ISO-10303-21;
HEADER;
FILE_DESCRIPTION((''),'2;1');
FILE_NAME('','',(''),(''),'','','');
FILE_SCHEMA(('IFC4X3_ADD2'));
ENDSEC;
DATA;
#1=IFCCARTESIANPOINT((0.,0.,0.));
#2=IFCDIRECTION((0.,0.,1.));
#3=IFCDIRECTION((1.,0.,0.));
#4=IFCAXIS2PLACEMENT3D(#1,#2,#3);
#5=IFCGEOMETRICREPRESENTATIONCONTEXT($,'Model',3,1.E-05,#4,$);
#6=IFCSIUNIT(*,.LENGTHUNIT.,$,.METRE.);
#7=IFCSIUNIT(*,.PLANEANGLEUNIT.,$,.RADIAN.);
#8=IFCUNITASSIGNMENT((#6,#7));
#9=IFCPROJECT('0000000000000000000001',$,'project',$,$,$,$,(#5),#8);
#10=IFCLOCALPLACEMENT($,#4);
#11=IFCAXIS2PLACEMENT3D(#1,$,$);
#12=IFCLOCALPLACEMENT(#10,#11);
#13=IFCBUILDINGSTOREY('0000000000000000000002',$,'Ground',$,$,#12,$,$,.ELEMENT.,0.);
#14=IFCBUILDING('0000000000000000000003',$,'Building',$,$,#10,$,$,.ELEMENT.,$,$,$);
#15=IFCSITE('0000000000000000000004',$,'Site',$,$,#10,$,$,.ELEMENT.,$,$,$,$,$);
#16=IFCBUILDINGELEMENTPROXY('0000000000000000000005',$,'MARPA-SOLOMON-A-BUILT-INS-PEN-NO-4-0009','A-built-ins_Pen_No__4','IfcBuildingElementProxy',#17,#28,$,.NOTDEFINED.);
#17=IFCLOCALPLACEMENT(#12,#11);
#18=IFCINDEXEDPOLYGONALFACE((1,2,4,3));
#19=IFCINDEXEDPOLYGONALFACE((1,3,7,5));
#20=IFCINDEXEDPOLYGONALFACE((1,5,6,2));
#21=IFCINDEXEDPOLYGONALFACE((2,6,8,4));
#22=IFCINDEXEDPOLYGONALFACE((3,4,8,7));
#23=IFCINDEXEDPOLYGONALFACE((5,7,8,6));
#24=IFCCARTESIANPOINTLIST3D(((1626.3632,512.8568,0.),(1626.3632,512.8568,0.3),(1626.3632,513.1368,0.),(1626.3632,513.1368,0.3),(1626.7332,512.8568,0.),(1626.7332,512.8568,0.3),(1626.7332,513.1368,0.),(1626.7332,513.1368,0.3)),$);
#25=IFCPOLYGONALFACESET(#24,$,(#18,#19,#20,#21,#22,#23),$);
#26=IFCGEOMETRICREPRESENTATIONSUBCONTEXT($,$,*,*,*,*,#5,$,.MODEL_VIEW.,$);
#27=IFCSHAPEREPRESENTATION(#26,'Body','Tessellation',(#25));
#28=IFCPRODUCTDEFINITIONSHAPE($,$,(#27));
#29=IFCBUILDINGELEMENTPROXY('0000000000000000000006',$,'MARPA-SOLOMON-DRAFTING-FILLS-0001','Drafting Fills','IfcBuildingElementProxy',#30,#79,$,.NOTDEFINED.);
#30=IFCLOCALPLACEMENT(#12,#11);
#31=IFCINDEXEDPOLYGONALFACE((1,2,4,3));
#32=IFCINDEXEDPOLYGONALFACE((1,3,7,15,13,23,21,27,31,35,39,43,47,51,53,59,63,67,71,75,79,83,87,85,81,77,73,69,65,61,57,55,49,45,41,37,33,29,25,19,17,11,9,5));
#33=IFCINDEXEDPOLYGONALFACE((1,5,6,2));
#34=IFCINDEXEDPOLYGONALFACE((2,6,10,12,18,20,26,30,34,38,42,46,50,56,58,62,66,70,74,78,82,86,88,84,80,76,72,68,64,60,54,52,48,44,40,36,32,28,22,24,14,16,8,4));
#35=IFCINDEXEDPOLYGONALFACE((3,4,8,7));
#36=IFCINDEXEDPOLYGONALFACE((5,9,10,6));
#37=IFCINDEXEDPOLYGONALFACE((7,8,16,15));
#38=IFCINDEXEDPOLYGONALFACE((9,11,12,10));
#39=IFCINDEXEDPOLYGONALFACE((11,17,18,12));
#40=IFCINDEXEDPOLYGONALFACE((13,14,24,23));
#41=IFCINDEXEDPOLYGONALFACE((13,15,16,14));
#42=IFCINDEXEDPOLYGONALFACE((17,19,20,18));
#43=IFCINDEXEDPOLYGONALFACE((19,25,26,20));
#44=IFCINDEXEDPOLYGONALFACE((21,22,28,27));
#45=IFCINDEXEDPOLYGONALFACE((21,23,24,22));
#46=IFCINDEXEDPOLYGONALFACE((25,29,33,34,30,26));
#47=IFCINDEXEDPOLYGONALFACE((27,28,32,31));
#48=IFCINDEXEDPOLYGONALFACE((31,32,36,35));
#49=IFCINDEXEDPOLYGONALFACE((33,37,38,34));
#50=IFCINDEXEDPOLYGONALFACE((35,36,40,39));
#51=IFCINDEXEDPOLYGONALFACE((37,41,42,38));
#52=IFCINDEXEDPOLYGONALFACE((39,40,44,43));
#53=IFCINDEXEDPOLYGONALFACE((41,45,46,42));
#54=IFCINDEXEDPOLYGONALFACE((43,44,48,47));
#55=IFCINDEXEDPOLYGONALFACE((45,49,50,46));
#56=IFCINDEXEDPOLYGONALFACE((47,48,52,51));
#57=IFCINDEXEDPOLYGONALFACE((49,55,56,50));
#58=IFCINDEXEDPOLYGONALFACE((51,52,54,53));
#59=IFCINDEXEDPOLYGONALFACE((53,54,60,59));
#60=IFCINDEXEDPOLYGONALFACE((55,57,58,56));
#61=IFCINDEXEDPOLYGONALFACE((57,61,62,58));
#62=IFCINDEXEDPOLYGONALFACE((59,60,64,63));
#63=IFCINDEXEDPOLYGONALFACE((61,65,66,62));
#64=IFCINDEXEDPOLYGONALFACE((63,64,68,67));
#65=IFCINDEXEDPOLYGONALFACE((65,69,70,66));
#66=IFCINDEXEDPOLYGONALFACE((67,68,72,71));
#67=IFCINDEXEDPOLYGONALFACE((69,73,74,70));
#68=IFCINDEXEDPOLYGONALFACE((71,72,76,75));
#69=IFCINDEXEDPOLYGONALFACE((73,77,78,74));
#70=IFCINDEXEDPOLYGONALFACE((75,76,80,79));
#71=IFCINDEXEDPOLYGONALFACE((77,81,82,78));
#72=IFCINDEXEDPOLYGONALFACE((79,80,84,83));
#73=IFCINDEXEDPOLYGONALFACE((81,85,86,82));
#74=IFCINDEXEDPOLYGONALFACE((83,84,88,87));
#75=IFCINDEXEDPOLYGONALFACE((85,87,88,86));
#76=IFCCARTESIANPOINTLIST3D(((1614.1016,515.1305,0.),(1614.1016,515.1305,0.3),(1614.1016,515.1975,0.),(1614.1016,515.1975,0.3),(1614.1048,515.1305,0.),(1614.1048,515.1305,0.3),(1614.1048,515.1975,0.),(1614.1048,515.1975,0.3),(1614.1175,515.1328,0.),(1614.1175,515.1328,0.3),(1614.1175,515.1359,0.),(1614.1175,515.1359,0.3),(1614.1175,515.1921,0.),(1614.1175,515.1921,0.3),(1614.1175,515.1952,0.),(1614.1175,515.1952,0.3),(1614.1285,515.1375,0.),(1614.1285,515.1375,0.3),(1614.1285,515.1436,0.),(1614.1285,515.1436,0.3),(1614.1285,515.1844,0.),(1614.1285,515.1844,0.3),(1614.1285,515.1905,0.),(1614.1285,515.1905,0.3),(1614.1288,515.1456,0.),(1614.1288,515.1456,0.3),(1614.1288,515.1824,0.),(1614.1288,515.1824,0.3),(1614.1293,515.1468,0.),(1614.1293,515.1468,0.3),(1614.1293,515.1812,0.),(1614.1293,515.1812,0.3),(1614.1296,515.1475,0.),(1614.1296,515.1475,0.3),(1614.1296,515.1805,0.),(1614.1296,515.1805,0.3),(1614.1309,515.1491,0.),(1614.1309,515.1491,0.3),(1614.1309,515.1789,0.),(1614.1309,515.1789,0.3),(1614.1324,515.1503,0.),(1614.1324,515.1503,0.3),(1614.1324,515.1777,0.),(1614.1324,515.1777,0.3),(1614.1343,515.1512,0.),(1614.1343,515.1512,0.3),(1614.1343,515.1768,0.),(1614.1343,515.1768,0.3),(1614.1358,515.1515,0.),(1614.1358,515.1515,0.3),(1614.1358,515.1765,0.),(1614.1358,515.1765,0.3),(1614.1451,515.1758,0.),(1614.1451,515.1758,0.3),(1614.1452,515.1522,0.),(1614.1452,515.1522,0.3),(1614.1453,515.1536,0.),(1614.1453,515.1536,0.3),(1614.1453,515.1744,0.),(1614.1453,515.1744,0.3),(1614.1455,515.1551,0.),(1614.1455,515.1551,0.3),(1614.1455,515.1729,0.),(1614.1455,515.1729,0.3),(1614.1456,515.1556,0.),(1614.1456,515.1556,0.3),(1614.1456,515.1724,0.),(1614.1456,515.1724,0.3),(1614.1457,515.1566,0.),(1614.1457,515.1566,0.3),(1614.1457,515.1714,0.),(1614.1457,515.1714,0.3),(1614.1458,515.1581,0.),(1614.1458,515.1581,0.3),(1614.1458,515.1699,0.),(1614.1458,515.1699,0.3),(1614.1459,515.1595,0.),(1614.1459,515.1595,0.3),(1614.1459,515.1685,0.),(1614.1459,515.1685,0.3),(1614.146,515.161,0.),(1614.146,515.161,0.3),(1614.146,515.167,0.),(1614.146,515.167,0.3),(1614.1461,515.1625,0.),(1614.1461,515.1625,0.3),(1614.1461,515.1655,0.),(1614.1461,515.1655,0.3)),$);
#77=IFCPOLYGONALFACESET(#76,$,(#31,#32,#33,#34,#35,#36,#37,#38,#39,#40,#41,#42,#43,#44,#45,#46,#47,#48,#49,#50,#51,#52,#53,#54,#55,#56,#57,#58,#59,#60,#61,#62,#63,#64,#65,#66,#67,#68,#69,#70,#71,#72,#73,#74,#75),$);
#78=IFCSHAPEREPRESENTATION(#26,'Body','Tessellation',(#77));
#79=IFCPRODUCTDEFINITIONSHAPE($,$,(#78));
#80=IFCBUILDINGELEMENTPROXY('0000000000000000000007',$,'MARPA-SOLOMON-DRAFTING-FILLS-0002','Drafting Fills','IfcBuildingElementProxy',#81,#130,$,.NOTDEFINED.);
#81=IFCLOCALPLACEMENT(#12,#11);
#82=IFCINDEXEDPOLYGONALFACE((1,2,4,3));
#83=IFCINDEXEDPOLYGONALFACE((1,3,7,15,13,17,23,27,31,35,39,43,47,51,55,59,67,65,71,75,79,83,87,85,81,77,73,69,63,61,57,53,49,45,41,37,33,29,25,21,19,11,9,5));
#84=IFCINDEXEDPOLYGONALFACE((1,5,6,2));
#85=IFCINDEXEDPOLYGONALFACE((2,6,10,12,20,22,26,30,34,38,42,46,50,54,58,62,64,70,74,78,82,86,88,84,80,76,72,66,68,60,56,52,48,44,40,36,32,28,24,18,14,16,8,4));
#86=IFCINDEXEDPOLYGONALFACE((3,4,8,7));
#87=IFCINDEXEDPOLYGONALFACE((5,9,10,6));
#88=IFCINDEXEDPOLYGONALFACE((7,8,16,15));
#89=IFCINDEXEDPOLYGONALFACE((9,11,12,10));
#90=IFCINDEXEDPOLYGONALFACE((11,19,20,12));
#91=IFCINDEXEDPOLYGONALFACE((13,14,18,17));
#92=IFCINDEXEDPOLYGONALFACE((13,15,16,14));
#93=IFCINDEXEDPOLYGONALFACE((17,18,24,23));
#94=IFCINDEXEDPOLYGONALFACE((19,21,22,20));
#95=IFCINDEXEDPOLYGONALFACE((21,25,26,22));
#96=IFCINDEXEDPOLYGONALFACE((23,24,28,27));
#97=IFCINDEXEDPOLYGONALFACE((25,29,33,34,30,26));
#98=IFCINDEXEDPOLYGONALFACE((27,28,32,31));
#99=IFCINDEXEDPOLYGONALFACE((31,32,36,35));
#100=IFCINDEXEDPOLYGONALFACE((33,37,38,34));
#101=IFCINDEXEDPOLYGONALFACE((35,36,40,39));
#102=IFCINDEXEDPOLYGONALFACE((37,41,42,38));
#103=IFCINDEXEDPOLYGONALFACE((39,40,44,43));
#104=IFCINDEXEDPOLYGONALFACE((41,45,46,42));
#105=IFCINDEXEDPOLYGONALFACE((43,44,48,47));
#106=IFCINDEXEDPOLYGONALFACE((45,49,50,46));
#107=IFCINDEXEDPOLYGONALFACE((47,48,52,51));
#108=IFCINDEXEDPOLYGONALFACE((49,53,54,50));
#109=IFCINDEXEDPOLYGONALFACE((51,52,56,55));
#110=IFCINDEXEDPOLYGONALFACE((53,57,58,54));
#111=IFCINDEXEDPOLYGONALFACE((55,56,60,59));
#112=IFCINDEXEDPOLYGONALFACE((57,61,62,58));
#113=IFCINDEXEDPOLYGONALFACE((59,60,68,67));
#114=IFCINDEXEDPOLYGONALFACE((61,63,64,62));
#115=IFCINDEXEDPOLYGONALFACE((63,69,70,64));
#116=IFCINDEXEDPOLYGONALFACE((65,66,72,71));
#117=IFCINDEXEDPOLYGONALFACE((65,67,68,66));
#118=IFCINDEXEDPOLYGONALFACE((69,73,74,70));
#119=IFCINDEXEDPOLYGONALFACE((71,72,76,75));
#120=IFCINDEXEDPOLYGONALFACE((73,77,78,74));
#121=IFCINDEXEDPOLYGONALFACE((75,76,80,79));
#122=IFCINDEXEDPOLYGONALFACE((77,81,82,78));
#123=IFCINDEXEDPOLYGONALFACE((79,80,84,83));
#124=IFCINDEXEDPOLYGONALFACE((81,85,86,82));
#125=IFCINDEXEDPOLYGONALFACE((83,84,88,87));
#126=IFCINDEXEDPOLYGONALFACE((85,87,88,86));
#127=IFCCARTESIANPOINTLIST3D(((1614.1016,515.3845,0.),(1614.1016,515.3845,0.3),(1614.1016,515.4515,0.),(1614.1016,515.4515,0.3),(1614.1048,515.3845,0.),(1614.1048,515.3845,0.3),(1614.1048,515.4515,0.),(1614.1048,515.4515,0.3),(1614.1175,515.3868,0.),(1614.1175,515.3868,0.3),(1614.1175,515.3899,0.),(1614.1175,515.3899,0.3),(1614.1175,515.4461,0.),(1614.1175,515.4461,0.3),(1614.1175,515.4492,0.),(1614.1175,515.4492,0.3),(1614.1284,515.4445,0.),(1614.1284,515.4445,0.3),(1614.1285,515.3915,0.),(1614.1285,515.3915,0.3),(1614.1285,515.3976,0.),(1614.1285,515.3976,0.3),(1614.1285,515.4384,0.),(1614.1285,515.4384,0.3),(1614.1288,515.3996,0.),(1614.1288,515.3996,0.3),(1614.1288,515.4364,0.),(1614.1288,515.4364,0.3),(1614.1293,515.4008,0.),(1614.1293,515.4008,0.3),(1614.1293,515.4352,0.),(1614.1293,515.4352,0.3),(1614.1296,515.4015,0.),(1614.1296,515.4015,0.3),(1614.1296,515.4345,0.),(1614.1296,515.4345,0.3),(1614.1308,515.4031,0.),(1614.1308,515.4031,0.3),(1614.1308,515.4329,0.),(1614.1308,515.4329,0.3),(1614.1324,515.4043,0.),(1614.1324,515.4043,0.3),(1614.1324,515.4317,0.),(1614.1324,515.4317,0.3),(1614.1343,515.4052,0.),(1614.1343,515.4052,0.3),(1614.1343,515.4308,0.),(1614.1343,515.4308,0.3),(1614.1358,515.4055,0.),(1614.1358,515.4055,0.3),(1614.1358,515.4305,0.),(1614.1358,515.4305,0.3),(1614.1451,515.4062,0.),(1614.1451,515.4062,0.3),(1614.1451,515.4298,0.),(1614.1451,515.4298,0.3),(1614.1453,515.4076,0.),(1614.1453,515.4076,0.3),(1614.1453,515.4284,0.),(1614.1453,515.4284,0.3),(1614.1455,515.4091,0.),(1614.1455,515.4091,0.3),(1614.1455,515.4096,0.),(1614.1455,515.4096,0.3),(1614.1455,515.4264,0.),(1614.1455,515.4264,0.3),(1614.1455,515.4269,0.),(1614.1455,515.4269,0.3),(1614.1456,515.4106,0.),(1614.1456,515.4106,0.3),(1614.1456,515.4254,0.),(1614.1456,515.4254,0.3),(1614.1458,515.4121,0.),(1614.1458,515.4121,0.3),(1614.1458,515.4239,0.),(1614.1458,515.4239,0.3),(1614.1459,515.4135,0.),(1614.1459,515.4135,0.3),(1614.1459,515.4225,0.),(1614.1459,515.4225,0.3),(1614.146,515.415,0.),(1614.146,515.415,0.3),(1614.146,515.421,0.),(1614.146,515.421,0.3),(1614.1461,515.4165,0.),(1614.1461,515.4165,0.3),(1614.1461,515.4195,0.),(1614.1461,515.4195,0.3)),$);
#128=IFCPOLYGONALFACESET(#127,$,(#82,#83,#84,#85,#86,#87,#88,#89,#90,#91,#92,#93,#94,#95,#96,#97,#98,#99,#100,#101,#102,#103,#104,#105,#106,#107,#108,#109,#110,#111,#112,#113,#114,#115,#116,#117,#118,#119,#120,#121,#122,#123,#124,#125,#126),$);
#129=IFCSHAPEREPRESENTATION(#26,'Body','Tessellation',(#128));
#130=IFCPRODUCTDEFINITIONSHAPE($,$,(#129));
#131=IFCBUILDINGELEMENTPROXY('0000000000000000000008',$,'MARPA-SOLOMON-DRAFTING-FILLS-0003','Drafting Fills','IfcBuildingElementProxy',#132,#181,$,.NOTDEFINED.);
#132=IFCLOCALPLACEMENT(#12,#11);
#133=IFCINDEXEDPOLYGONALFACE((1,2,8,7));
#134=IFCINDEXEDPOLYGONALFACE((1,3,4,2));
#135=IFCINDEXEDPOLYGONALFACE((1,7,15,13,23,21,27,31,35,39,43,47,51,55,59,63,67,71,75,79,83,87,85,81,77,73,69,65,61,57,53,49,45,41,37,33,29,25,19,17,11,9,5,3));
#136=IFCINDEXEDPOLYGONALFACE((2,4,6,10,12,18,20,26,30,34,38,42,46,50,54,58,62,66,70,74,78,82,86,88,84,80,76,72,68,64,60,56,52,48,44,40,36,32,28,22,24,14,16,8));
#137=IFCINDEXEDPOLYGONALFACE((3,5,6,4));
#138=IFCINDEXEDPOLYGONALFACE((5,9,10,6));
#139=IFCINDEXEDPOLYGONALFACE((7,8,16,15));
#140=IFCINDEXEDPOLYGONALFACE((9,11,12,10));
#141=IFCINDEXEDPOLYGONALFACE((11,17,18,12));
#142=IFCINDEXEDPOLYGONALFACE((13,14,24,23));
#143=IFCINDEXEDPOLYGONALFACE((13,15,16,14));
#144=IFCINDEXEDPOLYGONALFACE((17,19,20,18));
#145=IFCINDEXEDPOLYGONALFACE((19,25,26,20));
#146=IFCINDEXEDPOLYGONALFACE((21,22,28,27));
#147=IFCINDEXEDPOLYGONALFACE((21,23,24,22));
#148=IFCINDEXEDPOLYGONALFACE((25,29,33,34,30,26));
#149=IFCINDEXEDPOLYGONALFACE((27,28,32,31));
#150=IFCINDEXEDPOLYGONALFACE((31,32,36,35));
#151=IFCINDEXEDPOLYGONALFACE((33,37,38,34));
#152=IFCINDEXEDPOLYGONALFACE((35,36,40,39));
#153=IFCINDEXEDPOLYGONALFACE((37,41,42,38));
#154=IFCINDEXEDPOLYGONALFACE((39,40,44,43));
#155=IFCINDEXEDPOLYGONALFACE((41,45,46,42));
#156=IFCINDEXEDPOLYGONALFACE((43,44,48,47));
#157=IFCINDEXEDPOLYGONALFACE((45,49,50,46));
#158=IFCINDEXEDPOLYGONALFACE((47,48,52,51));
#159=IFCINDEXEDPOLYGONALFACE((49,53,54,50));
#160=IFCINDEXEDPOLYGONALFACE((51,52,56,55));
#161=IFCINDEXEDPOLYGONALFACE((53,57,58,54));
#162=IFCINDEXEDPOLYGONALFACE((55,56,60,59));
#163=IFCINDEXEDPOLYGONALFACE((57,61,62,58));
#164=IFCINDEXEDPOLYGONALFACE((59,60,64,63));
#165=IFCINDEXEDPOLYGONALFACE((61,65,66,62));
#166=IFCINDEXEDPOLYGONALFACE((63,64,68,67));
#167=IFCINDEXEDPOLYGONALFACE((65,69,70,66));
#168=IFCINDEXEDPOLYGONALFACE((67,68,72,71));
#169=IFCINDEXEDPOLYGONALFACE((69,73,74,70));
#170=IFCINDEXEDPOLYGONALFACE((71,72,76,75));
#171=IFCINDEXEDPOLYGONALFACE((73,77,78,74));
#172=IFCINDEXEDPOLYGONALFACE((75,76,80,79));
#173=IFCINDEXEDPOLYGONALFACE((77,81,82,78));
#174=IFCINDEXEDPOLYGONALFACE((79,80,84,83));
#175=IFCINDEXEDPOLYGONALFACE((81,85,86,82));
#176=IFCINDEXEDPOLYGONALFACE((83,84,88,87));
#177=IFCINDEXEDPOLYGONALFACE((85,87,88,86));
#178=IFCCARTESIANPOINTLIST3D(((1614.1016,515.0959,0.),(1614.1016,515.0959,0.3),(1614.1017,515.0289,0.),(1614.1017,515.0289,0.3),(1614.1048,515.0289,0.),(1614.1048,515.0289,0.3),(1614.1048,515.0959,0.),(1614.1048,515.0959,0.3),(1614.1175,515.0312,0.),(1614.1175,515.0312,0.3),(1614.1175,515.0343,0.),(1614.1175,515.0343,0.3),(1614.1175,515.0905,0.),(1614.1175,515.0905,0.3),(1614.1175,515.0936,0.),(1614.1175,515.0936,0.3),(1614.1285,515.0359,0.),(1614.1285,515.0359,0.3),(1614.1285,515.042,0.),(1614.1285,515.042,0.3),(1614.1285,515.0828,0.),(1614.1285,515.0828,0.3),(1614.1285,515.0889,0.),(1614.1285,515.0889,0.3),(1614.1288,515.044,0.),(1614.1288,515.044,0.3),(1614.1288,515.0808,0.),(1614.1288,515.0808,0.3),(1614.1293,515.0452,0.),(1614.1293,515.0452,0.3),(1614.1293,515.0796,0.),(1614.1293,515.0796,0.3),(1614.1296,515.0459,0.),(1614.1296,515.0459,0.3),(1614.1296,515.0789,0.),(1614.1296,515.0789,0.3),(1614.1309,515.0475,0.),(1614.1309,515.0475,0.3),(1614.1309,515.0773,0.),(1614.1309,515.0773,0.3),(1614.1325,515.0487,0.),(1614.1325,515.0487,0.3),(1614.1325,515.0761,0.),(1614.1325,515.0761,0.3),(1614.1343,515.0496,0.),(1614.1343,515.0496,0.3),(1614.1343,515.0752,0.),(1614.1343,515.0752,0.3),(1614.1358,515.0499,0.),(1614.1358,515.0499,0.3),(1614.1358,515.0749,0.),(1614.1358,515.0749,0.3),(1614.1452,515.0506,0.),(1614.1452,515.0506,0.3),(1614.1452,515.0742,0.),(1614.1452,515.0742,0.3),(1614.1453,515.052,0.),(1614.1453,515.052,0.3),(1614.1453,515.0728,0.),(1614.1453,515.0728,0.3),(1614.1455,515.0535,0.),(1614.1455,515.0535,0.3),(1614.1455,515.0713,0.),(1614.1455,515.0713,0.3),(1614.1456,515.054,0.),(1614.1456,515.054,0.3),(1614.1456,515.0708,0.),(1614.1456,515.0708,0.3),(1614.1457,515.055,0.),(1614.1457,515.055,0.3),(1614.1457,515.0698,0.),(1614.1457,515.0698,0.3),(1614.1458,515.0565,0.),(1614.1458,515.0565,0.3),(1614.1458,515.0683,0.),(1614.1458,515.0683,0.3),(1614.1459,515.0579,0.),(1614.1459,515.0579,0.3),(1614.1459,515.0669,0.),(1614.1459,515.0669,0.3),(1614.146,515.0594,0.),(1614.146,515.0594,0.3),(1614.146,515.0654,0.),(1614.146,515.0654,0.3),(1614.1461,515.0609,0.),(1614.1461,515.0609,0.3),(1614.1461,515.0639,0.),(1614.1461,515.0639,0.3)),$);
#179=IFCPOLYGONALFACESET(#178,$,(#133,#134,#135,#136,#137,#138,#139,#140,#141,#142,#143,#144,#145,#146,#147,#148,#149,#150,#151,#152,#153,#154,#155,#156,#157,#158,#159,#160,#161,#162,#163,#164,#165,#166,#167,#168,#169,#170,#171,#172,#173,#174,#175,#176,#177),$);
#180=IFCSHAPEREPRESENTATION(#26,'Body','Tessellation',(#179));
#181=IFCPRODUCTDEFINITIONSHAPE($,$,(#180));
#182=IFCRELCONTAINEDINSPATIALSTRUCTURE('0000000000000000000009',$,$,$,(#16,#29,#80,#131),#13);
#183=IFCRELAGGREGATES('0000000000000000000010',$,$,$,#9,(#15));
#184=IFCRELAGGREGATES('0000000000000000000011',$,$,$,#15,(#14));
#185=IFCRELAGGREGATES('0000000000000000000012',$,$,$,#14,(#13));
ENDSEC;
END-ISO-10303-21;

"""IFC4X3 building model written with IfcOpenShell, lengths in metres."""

from ifc_helpers import new_model, si_unit, frame, origin, origin_with_axes, place, context, subcontext, project, spatial, polyline, outline, extrude, element, save


model = new_model("IFC4X3")

# Units and contexts
model_context = context("Model", 3, precision=1e-05, world=origin_with_axes())
sub_context = subcontext(model_context, None, None, "MODEL_VIEW")
ifc_project = project(units=[si_unit("LENGTHUNIT", "METRE"), si_unit("PLANEANGLEUNIT", "RADIAN")], contexts=[model_context])

# Site, building, storey
placement = place(None, origin_with_axes())
site = spatial("IfcSite", under=ifc_project, at=placement, Name="Site", CompositionType="ELEMENT")
building = spatial("IfcBuilding", under=site, at=placement, Name="Building", CompositionType="ELEMENT")
storey_placement = place(placement, origin())
storey = spatial("IfcBuildingStorey", under=building, at=storey_placement, Name="Ground", CompositionType="ELEMENT", Elevation=0.0)

# Building element proxies
proxy_1_placement = place(placement, frame((1626.3632, 512.8568, 0.0)))
element("IfcBuildingElementProxy", 1, at=proxy_1_placement, inside=storey, Name="MARPA-SOLOMON-A-BUILT-INS-PEN-NO-4-0009", Description="A-built-ins_Pen_No__4", ObjectType="IfcBuildingElementProxy", PredefinedType="NOTDEFINED", context=sub_context, shape_type="SweptSolid", body=[
    extrude(outline(polyline([(0.0, 0.28), (0.0, 0.0), (0.37, 0.0), (0.37, 0.28), (0.0, 0.28)])), origin(), (0.0, 0.0, 1.0), 0.3),
])
proxy_2_placement = place(placement, frame((1614.1016, 515.1305, 0.0)))
element("IfcBuildingElementProxy", 2, at=proxy_2_placement, inside=storey, Name="MARPA-SOLOMON-DRAFTING-FILLS-0001", Description="Drafting Fills", ObjectType="IfcBuildingElementProxy", PredefinedType="NOTDEFINED", context=sub_context, shape_type="SweptSolid", body=[
    extrude(outline(polyline([(0.0159, 0.0022), (0.0159, 0.0054), (0.0268, 0.007), (0.0268, 0.0131), (0.0272, 0.0151), (0.0277, 0.0162), (0.028, 0.017), (0.0292, 0.0186), (0.0308, 0.0198), (0.0326, 0.0207), (0.0342, 0.021), (0.0435, 0.0216), (0.0437, 0.0231), (0.0439, 0.0246), (0.0439, 0.0251), (0.044, 0.0261), (0.0441, 0.0275), (0.0443, 0.029), (0.0443, 0.0305), (0.0445, 0.032), (0.0445, 0.035), (0.0443, 0.0365), (0.0442, 0.0379), (0.0441, 0.0394), (0.044, 0.0409), (0.0439, 0.0419), (0.0439, 0.0424), (0.0437, 0.0439), (0.0435, 0.0453), (0.0342, 0.046), (0.0326, 0.0463), (0.0308, 0.0471), (0.0292, 0.0484), (0.028, 0.05), (0.0277, 0.0507), (0.0272, 0.0519), (0.0268, 0.0538), (0.0268, 0.06), (0.0159, 0.0616), (0.0159, 0.0647), (0.0032, 0.067), (0.0, 0.067), (0.0, 0.0), (0.0032, 0.0), (0.0159, 0.0022)])), origin(), (0.0, 0.0, 1.0), 0.3),
])
proxy_3_placement = place(placement, frame((1614.1016, 515.3845, 0.0)))
element("IfcBuildingElementProxy", 3, at=proxy_3_placement, inside=storey, Name="MARPA-SOLOMON-DRAFTING-FILLS-0002", Description="Drafting Fills", ObjectType="IfcBuildingElementProxy", PredefinedType="NOTDEFINED", context=sub_context, shape_type="SweptSolid", body=[
    extrude(outline(polyline([(0.0159, 0.0022), (0.0159, 0.0054), (0.0268, 0.007), (0.0268, 0.0131), (0.0272, 0.0151), (0.0277, 0.0162), (0.028, 0.017), (0.0292, 0.0186), (0.0308, 0.0198), (0.0326, 0.0207), (0.0342, 0.021), (0.0435, 0.0216), (0.0437, 0.0231), (0.0439, 0.0246), (0.0439, 0.0251), (0.044, 0.0261), (0.0441, 0.0275), (0.0443, 0.029), (0.0443, 0.0305), (0.0445, 0.032), (0.0445, 0.035), (0.0443, 0.0365), (0.0442, 0.0379), (0.0441, 0.0394), (0.044, 0.0409), (0.0439, 0.0419), (0.0439, 0.0424), (0.0437, 0.0439), (0.0435, 0.0453), (0.0342, 0.046), (0.0326, 0.0463), (0.0308, 0.0471), (0.0292, 0.0484), (0.028, 0.05), (0.0277, 0.0507), (0.0272, 0.0519), (0.0268, 0.0538), (0.0268, 0.06), (0.0159, 0.0616), (0.0159, 0.0647), (0.0032, 0.067), (0.0, 0.067), (0.0, 0.0), (0.0032, 0.0), (0.0159, 0.0022)])), origin(), (0.0, 0.0, 1.0), 0.3),
])
proxy_4_placement = place(placement, frame((1614.1016, 515.0289, 0.0)))
element("IfcBuildingElementProxy", 4, at=proxy_4_placement, inside=storey, Name="MARPA-SOLOMON-DRAFTING-FILLS-0003", Description="Drafting Fills", ObjectType="IfcBuildingElementProxy", PredefinedType="NOTDEFINED", context=sub_context, shape_type="SweptSolid", body=[
    extrude(outline(polyline([(0.0159, 0.0022), (0.0159, 0.0054), (0.0268, 0.007), (0.0268, 0.0131), (0.0272, 0.0151), (0.0277, 0.0162), (0.028, 0.017), (0.0292, 0.0186), (0.0308, 0.0198), (0.0326, 0.0207), (0.0342, 0.021), (0.0435, 0.0216), (0.0437, 0.0231), (0.0439, 0.0246), (0.0439, 0.0251), (0.044, 0.0261), (0.0441, 0.0275), (0.0443, 0.029), (0.0443, 0.0305), (0.0445, 0.032), (0.0445, 0.035), (0.0443, 0.0365), (0.0442, 0.0379), (0.0441, 0.0394), (0.044, 0.0409), (0.0439, 0.0419), (0.0439, 0.0424), (0.0437, 0.0439), (0.0435, 0.0453), (0.0342, 0.046), (0.0326, 0.0463), (0.0308, 0.0471), (0.0292, 0.0484), (0.028, 0.05), (0.0277, 0.0507), (0.0272, 0.0519), (0.0268, 0.0538), (0.0268, 0.06), (0.0159, 0.0616), (0.0159, 0.0647), (0.0032, 0.067), (0.0, 0.067), (0.0, 0.0), (0.0032, 0.0), (0.0159, 0.0022)])), origin(), (0.0, 0.0, 1.0), 0.3),
])

save(model, "model.ifc")
